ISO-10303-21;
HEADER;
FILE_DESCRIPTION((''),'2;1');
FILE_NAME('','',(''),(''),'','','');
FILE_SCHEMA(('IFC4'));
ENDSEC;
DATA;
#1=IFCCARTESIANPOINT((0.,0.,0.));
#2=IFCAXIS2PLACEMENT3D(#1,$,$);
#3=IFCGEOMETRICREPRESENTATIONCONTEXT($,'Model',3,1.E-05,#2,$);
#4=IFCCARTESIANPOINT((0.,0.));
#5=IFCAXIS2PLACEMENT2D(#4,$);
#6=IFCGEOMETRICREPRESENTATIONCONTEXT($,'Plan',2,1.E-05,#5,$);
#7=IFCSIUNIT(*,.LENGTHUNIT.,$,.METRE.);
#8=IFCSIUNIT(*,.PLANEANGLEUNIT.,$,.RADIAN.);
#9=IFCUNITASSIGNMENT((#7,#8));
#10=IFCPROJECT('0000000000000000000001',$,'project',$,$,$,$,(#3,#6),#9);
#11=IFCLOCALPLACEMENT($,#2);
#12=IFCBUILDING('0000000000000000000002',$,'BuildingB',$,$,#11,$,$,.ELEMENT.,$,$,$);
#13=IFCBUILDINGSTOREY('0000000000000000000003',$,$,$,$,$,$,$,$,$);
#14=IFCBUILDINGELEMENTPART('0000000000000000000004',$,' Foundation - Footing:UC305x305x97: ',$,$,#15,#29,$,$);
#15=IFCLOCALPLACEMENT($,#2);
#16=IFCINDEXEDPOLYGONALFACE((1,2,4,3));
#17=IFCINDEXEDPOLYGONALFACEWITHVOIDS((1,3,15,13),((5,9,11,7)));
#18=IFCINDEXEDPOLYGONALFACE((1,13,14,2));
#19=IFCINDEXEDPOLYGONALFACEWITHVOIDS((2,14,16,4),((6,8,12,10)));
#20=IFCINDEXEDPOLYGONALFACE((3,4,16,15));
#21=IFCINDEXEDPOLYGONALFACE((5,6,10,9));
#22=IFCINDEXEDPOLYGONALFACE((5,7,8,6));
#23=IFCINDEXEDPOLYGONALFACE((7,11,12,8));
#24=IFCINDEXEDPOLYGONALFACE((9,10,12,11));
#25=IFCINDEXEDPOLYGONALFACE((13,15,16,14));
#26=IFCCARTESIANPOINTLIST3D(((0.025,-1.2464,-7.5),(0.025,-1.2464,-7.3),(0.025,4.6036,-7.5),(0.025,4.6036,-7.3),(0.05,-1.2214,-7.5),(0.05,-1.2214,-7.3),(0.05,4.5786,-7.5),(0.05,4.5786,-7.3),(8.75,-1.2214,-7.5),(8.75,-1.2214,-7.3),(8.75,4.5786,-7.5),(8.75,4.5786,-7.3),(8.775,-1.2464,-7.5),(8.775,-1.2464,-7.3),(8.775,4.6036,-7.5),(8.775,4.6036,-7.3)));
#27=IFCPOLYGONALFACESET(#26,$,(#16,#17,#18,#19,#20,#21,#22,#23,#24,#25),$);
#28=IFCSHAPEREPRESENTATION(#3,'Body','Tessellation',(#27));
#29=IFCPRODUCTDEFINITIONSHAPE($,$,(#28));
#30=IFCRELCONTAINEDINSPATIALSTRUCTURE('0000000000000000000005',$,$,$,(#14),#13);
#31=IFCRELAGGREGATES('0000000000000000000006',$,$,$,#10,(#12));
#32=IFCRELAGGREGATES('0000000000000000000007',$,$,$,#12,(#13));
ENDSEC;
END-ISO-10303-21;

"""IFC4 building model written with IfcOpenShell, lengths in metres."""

from ifc_helpers import new_model, si_unit, origin, origin_2d, place, context, project, spatial, polyline, outline, extrude, element, save


model = new_model("IFC4")

# Units and contexts
model_context = context("Model", 3, precision=1e-05, world=origin())
plan_context = context("Plan", 2, precision=1e-05, world=origin_2d())
ifc_project = project(units=[si_unit("LENGTHUNIT", "METRE"), si_unit("PLANEANGLEUNIT", "RADIAN")], contexts=[model_context, plan_context])

# Building, storey
building_placement = place(None, origin())
building = spatial("IfcBuilding", under=ifc_project, at=building_placement, Name="BuildingB", CompositionType="ELEMENT")
storey = spatial("IfcBuildingStorey", under=building)

# Building element part, opening
building_element_part_1 = element("IfcBuildingElementPart", 1, inside=storey, Name=" Foundation - Footing:UC305x305x97: ", context=model_context, shape_type="SweptSolid", body=[
    extrude(outline(polyline([(0.025, -1.2464, -7.5), (8.775, -1.2464, -7.5), (8.775, 4.6036, -7.5), (0.025, 4.6036, -7.5), (0.025, -1.2464, -7.5)])), None, (0.0, 0.0, 1.0), 0.2),
])
element("IfcOpeningElement", 2, inside=storey, cuts=building_element_part_1, context=model_context, shape_type="SweptSolid", body=[
    extrude(outline(polyline([(0.05, -1.2214, -7.5), (8.75, -1.2214, -7.5), (8.75, 4.5786, -7.5), (0.05, 4.5786, -7.5), (0.05, -1.2214, -7.5)])), None, (0.0, 0.0, 1.0), 0.2),
])

save(model, "model.ifc")
